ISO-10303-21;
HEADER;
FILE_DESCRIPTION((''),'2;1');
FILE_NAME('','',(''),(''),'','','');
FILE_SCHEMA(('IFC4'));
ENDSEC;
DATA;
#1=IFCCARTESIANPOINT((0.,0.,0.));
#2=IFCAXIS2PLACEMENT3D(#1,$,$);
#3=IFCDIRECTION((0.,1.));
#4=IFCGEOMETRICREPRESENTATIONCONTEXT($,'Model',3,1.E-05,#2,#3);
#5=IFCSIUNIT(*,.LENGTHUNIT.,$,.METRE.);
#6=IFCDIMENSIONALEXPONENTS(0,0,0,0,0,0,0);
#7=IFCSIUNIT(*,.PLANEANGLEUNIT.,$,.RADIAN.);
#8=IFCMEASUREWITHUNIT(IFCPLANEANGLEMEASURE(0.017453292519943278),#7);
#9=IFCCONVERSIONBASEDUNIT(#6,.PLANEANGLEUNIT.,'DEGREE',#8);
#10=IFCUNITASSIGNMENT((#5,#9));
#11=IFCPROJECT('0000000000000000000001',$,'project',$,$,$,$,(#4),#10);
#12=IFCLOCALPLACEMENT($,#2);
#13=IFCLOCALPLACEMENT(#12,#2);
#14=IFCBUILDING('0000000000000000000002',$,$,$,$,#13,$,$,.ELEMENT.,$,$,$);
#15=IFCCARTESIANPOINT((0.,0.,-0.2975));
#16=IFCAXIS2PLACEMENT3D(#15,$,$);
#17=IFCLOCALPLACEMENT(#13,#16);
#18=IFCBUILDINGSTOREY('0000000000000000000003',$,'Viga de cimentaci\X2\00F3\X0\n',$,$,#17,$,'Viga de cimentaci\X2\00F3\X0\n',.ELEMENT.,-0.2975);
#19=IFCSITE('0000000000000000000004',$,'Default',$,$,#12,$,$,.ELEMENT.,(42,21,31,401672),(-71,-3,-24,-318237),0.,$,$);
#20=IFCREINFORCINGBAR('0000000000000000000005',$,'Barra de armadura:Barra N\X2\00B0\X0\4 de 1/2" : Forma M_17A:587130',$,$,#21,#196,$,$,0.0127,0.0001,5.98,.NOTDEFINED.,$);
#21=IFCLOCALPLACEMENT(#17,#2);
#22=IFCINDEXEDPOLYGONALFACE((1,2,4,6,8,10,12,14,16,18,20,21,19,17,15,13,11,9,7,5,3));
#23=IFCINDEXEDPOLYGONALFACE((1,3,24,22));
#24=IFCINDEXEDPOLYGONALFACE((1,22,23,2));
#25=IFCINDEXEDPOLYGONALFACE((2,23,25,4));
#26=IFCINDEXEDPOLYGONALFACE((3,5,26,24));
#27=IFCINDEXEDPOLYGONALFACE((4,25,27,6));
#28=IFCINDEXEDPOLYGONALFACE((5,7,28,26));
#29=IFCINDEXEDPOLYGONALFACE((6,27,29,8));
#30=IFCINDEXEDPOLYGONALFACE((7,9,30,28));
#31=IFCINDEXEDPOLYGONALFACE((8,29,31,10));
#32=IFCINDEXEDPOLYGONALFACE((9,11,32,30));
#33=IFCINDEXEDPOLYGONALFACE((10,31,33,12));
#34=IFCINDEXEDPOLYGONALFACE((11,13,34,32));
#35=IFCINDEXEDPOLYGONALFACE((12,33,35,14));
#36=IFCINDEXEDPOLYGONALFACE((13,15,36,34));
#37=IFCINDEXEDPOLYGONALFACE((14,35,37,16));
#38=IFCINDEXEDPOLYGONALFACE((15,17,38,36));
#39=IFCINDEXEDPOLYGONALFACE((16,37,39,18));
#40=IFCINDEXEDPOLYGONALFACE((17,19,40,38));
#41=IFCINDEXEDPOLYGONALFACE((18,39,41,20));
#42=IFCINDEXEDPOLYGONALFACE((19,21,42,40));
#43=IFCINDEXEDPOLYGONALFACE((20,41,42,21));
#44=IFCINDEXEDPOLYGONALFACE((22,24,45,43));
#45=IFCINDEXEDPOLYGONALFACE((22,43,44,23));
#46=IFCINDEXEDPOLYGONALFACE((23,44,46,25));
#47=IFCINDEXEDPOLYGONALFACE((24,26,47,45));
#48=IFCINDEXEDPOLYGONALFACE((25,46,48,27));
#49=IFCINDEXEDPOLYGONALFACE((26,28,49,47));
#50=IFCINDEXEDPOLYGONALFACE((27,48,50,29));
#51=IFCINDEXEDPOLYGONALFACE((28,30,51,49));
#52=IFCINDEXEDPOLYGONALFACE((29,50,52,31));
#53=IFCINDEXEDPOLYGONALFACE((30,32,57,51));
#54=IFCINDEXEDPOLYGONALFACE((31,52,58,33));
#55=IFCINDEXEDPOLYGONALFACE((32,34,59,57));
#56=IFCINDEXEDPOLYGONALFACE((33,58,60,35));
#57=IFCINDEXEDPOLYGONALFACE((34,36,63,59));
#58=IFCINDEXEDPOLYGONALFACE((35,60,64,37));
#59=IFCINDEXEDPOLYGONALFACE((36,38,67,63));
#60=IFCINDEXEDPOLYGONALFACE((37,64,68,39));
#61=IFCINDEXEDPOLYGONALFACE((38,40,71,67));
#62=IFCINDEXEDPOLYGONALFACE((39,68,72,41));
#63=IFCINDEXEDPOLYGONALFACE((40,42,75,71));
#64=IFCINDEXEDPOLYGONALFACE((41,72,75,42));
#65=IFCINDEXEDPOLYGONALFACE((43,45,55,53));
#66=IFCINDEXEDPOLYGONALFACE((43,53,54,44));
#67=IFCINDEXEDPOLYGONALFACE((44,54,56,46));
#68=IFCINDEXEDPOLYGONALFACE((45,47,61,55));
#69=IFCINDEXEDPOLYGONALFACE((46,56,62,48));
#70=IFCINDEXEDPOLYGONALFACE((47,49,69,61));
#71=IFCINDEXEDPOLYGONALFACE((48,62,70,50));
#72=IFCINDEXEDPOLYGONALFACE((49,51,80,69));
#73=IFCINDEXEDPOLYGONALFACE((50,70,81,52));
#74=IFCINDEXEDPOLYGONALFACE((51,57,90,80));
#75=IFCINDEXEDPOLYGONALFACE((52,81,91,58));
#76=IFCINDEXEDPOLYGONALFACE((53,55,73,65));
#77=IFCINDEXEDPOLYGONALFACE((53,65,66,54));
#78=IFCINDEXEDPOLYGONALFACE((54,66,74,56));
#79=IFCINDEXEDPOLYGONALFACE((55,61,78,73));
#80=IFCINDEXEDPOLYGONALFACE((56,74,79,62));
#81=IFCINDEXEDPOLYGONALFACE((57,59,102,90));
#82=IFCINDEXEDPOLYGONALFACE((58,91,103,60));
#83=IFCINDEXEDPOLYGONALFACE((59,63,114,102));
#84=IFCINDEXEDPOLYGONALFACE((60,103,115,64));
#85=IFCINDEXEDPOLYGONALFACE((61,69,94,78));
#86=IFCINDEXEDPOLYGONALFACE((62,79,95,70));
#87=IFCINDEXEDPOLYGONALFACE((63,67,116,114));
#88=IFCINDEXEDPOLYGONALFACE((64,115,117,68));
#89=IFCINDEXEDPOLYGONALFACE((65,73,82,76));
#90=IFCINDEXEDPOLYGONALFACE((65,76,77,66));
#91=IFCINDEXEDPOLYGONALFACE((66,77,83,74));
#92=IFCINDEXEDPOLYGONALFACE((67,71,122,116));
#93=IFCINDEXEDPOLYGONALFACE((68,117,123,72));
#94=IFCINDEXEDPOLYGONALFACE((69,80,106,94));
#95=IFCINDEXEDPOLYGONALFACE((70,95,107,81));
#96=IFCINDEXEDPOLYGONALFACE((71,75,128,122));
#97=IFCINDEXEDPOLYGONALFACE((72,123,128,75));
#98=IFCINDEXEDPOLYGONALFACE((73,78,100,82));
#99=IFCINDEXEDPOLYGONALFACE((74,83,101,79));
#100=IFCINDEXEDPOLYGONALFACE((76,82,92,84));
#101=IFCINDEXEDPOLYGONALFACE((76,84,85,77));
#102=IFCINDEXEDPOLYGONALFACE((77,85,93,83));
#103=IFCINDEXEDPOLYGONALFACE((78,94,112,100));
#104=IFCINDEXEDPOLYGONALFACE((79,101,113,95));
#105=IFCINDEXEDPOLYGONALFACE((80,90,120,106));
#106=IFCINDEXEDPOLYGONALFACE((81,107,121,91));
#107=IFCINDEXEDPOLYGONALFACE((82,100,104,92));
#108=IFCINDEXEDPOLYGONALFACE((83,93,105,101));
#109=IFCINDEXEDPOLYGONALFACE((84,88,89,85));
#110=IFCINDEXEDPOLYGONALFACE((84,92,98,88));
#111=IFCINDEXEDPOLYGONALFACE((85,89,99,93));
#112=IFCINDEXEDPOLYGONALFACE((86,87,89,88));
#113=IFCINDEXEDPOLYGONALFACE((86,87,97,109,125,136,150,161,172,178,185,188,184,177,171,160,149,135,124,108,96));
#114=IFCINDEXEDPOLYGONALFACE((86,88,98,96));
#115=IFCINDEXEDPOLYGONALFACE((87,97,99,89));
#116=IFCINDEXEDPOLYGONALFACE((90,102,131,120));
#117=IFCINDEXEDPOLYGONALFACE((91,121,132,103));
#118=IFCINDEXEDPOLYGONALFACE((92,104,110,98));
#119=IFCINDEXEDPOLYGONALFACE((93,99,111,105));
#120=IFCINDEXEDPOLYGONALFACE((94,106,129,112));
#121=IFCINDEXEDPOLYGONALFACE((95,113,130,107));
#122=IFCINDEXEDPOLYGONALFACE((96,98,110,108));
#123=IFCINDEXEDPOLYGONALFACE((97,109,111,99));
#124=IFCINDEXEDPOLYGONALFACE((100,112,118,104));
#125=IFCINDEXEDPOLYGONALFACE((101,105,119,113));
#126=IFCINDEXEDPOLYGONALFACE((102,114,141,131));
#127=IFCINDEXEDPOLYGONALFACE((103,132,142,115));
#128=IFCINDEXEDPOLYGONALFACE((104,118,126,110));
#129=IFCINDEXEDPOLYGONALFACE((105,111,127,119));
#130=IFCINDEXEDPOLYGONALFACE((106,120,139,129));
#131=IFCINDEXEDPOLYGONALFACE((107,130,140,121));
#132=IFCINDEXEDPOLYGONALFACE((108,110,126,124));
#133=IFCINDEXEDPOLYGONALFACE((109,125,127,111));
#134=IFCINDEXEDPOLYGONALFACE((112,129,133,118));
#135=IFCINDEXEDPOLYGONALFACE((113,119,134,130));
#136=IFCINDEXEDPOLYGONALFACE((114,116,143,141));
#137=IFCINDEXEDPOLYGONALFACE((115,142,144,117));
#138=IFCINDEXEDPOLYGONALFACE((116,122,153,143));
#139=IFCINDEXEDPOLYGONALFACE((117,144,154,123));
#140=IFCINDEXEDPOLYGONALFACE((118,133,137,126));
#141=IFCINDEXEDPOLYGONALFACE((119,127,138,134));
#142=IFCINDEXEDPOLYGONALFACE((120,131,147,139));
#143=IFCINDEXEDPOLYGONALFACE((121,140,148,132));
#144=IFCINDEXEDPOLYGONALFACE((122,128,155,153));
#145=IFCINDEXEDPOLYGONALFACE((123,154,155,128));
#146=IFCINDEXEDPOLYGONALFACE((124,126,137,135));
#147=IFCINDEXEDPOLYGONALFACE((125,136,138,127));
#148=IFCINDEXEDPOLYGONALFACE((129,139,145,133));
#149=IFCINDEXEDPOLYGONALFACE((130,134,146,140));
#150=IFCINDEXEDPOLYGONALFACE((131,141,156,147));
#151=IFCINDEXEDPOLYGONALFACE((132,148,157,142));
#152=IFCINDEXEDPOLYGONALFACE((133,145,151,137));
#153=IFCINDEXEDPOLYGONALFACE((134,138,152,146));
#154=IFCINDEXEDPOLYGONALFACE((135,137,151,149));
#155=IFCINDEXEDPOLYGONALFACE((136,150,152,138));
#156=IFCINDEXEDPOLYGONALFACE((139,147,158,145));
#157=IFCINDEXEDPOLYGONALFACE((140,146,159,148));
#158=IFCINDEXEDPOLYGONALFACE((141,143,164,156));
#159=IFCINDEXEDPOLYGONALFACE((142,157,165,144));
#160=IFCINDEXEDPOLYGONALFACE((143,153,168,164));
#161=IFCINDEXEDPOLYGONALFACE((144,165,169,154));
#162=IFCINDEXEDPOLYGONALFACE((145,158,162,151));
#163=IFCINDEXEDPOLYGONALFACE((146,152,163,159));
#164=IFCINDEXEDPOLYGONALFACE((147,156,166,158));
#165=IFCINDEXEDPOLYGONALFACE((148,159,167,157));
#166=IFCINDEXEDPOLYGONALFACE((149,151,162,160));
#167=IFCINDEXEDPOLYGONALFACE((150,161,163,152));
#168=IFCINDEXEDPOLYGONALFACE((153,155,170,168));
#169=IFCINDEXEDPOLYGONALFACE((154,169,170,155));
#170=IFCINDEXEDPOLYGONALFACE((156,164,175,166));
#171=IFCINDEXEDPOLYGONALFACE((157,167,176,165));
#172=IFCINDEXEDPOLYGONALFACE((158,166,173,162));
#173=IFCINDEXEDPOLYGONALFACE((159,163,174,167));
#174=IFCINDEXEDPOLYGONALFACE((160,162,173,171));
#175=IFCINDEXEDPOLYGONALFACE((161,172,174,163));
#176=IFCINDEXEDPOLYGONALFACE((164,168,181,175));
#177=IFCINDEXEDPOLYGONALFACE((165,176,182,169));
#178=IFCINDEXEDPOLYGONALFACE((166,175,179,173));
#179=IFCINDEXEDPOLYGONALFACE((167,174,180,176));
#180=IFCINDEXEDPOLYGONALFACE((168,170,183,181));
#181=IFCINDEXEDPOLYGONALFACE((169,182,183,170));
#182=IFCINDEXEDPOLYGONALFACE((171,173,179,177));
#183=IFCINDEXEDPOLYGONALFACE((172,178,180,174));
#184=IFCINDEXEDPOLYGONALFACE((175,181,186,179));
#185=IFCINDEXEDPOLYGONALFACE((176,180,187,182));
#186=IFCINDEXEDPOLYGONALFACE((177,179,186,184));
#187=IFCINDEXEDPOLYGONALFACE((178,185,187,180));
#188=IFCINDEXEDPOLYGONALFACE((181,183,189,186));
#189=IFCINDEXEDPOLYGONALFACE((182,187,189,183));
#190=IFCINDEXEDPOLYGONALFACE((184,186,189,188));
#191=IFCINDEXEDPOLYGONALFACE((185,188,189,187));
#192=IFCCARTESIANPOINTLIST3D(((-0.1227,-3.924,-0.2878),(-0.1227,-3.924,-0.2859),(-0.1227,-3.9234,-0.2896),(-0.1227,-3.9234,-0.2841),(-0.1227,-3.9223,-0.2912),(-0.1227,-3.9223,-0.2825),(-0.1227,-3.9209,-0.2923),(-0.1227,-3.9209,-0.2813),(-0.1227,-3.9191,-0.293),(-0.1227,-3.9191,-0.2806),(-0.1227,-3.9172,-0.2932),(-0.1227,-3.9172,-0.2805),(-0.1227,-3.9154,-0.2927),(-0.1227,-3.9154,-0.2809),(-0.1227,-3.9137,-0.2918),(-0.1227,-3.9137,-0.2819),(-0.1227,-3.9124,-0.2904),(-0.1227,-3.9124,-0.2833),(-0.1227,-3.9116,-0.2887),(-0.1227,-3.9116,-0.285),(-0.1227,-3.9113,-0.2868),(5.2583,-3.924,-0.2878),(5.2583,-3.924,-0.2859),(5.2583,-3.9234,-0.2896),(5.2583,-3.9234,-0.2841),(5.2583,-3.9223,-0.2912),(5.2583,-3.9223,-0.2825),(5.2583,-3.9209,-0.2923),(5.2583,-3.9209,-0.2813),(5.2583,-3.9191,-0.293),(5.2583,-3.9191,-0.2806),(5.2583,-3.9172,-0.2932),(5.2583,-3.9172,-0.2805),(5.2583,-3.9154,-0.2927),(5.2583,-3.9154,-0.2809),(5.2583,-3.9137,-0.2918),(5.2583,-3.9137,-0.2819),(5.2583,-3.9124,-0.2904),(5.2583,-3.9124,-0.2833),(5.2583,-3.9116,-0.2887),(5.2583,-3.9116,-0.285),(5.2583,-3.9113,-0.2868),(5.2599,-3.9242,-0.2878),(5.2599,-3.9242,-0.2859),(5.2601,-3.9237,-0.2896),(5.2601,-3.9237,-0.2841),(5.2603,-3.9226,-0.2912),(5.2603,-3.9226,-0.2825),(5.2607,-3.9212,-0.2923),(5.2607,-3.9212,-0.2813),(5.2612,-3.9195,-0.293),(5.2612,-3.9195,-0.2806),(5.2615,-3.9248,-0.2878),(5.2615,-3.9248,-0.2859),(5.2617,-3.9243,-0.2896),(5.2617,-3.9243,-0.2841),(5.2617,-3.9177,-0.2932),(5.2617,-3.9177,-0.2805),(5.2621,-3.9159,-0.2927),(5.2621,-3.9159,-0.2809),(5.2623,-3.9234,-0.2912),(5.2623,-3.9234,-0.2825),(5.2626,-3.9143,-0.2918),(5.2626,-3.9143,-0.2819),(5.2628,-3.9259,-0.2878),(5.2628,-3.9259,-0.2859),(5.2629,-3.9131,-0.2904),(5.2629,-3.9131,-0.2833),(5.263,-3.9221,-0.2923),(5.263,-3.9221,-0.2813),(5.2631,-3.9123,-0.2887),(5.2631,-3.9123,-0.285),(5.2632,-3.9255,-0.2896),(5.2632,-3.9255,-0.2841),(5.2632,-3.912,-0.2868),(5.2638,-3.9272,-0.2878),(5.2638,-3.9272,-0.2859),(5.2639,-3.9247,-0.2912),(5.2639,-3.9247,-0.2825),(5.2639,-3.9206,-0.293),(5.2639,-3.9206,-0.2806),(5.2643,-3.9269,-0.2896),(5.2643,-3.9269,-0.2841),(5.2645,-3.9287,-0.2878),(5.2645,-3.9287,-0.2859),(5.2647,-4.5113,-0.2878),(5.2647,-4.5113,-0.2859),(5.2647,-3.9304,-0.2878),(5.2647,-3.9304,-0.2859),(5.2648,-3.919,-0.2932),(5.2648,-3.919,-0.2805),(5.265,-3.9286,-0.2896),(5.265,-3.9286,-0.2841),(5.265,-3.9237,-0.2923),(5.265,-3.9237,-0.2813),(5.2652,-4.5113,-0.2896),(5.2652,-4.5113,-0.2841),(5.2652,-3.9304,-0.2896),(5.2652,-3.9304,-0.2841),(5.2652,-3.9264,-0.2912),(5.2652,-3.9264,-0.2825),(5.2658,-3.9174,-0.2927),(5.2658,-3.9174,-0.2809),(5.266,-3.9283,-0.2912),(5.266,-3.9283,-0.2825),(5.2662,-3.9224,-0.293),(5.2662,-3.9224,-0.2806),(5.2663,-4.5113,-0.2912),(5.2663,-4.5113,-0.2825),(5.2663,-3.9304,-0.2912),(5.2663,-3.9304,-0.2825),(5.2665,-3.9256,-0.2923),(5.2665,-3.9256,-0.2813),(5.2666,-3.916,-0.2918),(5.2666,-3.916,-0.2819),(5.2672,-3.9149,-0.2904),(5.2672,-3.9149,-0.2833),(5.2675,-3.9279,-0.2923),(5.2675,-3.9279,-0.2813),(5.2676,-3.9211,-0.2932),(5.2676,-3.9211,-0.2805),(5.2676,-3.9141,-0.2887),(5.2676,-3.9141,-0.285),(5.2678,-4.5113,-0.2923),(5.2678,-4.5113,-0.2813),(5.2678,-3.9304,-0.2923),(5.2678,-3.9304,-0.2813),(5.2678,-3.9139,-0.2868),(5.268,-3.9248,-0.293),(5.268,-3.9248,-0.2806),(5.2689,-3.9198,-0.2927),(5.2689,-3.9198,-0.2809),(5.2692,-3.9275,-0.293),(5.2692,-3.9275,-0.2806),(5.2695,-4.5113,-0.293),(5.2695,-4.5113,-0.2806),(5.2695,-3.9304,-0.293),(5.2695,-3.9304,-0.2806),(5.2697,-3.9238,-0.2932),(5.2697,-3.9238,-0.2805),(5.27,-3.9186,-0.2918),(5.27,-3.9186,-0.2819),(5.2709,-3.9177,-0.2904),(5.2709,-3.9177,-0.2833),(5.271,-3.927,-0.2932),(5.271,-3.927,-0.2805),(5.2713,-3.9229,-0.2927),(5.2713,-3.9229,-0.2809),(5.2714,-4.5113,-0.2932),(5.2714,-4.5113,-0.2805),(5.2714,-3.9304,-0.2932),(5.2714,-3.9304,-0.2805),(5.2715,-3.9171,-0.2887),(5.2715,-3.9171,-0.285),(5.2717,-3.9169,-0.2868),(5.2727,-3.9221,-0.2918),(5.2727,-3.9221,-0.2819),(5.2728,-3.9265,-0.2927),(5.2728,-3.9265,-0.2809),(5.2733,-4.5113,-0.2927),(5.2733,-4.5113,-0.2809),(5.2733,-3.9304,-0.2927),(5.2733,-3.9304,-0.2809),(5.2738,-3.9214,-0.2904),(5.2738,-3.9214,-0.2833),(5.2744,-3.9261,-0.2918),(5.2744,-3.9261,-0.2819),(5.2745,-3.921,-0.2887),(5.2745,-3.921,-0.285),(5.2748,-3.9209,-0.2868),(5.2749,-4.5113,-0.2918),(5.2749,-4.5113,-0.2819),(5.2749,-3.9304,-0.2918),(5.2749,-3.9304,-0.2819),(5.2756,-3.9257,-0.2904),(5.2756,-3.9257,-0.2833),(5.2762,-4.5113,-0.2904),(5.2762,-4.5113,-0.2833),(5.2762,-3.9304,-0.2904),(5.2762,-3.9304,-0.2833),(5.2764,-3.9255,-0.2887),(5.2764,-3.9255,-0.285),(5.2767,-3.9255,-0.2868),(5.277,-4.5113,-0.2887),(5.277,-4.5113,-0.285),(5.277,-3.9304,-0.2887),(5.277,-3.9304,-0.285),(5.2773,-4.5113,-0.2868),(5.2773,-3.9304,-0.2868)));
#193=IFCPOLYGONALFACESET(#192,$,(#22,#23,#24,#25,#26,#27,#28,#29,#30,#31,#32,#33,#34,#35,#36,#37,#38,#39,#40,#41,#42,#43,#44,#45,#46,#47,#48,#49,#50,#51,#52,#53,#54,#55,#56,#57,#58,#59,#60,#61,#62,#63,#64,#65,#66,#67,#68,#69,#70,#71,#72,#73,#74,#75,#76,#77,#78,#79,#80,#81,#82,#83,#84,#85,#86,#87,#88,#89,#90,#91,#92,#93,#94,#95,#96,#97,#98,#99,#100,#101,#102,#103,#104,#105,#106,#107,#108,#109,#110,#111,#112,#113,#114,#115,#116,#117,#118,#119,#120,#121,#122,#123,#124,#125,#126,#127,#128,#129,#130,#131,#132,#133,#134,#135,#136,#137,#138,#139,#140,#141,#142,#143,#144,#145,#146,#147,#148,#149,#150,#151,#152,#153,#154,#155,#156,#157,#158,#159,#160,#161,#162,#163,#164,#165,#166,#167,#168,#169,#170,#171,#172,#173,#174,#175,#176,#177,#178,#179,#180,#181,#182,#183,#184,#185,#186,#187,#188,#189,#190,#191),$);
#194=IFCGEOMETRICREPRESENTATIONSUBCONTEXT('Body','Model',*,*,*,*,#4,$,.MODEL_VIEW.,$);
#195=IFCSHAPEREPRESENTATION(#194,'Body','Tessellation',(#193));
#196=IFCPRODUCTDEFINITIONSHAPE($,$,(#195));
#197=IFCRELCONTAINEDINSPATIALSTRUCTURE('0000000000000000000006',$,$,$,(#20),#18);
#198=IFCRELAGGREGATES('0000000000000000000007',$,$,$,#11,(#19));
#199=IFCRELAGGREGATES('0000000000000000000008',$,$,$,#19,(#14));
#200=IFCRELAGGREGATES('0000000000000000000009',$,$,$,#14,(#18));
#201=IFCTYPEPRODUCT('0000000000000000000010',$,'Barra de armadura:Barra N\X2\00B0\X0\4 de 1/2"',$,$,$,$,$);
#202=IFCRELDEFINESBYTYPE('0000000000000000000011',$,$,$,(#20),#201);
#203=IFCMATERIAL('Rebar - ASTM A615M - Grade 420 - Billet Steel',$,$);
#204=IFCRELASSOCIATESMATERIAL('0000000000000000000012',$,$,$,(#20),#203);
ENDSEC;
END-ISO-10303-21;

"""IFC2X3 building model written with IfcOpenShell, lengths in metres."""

from ifc_helpers import new_model, entity, si_unit, converted_unit, direction, frame, origin, place, context, subcontext, project, spatial, material, type_object, element, save


model = new_model("IFC2X3")

# Units and contexts
model_context = context("Model", 3, precision=1e-05, world=origin(), true_north=direction((0.0, 1.0)))
body_context = subcontext(model_context, "Body", "Model", "MODEL_VIEW")
ifc_project = project(units=[si_unit("LENGTHUNIT", "METRE"), converted_unit("PLANEANGLEUNIT", "DEGREE", entity("IfcPlaneAngleMeasure", 0.017453292519943278), si_unit("PLANEANGLEUNIT", "RADIAN"), dimensions=[0, 0, 0, 0, 0, 0, 0])], contexts=[model_context])

# Site, building, storey
site_placement = place(None, origin())
site = spatial("IfcSite", under=ifc_project, at=site_placement, Name="Default", CompositionType="ELEMENT", RefLatitude=(42, 21, 31, 401672), RefLongitude=(-71, -3, -24, -318237), RefElevation=0.0)
building_placement = place(site_placement, origin())
building = spatial("IfcBuilding", under=site, at=building_placement, CompositionType="ELEMENT")
storey_placement = place(building_placement, frame((0.0, 0.0, -0.2975)))
storey = spatial("IfcBuildingStorey", under=building, at=storey_placement, Name="Viga de cimentación", LongName="Viga de cimentación", CompositionType="ELEMENT", Elevation=-0.2975)

# Reinforcing bar
ifc_material = material(Name="Rebar - ASTM A615M - Grade 420 - Billet Steel")
type_product_1 = type_object("IfcTypeProduct", Name="Barra de armadura:Barra N°4 de 1/2\"")
reinforcing_bar_1_placement = place(storey_placement, origin())
element("IfcReinforcingBar", 1, at=reinforcing_bar_1_placement, inside=storey, type_object=type_product_1, material=ifc_material, Name="Barra de armadura:Barra N°4 de 1/2\" : Forma M_17A:587130", BarLength=5.98, BarRole="NOTDEFINED", CrossSectionArea=0.0001, NominalDiameter=0.0127, context=body_context, shape_type="AdvancedSweptSolid", body=[
    entity("IfcSweptDiskSolid", entity("IfcCompositeCurve", [entity("IfcCompositeCurveSegment", "CONTINUOUS", True, entity("IfcPolyline", [entity("IfcCartesianPoint", [5.271, -4.5113, -0.2868]), entity("IfcCartesianPoint", [5.271, -3.9304, -0.2868])])), entity("IfcCompositeCurveSegment", "CONTINUOUS", True, entity("IfcTrimmedCurve", entity("IfcCircle", entity("IfcAxis2Placement3D", entity("IfcCartesianPoint", [5.2583, -3.9304, -0.2868]), entity("IfcDirection", [0.0, 0.0, 1.0]), entity("IfcDirection", [0.0, 1.0, 0.0])), 0.0127), [entity("IfcParameterValue", 270.0)], [entity("IfcParameterValue", 360.0)], True, "PARAMETER")), entity("IfcCompositeCurveSegment", "CONTINUOUS", True, entity("IfcPolyline", [entity("IfcCartesianPoint", [5.2583, -3.9177, -0.2868]), entity("IfcCartesianPoint", [-0.1227, -3.9177, -0.2868])]))], False), 0.0063, None, 0.0, 92.0),
])

save(model, "model.ifc")
